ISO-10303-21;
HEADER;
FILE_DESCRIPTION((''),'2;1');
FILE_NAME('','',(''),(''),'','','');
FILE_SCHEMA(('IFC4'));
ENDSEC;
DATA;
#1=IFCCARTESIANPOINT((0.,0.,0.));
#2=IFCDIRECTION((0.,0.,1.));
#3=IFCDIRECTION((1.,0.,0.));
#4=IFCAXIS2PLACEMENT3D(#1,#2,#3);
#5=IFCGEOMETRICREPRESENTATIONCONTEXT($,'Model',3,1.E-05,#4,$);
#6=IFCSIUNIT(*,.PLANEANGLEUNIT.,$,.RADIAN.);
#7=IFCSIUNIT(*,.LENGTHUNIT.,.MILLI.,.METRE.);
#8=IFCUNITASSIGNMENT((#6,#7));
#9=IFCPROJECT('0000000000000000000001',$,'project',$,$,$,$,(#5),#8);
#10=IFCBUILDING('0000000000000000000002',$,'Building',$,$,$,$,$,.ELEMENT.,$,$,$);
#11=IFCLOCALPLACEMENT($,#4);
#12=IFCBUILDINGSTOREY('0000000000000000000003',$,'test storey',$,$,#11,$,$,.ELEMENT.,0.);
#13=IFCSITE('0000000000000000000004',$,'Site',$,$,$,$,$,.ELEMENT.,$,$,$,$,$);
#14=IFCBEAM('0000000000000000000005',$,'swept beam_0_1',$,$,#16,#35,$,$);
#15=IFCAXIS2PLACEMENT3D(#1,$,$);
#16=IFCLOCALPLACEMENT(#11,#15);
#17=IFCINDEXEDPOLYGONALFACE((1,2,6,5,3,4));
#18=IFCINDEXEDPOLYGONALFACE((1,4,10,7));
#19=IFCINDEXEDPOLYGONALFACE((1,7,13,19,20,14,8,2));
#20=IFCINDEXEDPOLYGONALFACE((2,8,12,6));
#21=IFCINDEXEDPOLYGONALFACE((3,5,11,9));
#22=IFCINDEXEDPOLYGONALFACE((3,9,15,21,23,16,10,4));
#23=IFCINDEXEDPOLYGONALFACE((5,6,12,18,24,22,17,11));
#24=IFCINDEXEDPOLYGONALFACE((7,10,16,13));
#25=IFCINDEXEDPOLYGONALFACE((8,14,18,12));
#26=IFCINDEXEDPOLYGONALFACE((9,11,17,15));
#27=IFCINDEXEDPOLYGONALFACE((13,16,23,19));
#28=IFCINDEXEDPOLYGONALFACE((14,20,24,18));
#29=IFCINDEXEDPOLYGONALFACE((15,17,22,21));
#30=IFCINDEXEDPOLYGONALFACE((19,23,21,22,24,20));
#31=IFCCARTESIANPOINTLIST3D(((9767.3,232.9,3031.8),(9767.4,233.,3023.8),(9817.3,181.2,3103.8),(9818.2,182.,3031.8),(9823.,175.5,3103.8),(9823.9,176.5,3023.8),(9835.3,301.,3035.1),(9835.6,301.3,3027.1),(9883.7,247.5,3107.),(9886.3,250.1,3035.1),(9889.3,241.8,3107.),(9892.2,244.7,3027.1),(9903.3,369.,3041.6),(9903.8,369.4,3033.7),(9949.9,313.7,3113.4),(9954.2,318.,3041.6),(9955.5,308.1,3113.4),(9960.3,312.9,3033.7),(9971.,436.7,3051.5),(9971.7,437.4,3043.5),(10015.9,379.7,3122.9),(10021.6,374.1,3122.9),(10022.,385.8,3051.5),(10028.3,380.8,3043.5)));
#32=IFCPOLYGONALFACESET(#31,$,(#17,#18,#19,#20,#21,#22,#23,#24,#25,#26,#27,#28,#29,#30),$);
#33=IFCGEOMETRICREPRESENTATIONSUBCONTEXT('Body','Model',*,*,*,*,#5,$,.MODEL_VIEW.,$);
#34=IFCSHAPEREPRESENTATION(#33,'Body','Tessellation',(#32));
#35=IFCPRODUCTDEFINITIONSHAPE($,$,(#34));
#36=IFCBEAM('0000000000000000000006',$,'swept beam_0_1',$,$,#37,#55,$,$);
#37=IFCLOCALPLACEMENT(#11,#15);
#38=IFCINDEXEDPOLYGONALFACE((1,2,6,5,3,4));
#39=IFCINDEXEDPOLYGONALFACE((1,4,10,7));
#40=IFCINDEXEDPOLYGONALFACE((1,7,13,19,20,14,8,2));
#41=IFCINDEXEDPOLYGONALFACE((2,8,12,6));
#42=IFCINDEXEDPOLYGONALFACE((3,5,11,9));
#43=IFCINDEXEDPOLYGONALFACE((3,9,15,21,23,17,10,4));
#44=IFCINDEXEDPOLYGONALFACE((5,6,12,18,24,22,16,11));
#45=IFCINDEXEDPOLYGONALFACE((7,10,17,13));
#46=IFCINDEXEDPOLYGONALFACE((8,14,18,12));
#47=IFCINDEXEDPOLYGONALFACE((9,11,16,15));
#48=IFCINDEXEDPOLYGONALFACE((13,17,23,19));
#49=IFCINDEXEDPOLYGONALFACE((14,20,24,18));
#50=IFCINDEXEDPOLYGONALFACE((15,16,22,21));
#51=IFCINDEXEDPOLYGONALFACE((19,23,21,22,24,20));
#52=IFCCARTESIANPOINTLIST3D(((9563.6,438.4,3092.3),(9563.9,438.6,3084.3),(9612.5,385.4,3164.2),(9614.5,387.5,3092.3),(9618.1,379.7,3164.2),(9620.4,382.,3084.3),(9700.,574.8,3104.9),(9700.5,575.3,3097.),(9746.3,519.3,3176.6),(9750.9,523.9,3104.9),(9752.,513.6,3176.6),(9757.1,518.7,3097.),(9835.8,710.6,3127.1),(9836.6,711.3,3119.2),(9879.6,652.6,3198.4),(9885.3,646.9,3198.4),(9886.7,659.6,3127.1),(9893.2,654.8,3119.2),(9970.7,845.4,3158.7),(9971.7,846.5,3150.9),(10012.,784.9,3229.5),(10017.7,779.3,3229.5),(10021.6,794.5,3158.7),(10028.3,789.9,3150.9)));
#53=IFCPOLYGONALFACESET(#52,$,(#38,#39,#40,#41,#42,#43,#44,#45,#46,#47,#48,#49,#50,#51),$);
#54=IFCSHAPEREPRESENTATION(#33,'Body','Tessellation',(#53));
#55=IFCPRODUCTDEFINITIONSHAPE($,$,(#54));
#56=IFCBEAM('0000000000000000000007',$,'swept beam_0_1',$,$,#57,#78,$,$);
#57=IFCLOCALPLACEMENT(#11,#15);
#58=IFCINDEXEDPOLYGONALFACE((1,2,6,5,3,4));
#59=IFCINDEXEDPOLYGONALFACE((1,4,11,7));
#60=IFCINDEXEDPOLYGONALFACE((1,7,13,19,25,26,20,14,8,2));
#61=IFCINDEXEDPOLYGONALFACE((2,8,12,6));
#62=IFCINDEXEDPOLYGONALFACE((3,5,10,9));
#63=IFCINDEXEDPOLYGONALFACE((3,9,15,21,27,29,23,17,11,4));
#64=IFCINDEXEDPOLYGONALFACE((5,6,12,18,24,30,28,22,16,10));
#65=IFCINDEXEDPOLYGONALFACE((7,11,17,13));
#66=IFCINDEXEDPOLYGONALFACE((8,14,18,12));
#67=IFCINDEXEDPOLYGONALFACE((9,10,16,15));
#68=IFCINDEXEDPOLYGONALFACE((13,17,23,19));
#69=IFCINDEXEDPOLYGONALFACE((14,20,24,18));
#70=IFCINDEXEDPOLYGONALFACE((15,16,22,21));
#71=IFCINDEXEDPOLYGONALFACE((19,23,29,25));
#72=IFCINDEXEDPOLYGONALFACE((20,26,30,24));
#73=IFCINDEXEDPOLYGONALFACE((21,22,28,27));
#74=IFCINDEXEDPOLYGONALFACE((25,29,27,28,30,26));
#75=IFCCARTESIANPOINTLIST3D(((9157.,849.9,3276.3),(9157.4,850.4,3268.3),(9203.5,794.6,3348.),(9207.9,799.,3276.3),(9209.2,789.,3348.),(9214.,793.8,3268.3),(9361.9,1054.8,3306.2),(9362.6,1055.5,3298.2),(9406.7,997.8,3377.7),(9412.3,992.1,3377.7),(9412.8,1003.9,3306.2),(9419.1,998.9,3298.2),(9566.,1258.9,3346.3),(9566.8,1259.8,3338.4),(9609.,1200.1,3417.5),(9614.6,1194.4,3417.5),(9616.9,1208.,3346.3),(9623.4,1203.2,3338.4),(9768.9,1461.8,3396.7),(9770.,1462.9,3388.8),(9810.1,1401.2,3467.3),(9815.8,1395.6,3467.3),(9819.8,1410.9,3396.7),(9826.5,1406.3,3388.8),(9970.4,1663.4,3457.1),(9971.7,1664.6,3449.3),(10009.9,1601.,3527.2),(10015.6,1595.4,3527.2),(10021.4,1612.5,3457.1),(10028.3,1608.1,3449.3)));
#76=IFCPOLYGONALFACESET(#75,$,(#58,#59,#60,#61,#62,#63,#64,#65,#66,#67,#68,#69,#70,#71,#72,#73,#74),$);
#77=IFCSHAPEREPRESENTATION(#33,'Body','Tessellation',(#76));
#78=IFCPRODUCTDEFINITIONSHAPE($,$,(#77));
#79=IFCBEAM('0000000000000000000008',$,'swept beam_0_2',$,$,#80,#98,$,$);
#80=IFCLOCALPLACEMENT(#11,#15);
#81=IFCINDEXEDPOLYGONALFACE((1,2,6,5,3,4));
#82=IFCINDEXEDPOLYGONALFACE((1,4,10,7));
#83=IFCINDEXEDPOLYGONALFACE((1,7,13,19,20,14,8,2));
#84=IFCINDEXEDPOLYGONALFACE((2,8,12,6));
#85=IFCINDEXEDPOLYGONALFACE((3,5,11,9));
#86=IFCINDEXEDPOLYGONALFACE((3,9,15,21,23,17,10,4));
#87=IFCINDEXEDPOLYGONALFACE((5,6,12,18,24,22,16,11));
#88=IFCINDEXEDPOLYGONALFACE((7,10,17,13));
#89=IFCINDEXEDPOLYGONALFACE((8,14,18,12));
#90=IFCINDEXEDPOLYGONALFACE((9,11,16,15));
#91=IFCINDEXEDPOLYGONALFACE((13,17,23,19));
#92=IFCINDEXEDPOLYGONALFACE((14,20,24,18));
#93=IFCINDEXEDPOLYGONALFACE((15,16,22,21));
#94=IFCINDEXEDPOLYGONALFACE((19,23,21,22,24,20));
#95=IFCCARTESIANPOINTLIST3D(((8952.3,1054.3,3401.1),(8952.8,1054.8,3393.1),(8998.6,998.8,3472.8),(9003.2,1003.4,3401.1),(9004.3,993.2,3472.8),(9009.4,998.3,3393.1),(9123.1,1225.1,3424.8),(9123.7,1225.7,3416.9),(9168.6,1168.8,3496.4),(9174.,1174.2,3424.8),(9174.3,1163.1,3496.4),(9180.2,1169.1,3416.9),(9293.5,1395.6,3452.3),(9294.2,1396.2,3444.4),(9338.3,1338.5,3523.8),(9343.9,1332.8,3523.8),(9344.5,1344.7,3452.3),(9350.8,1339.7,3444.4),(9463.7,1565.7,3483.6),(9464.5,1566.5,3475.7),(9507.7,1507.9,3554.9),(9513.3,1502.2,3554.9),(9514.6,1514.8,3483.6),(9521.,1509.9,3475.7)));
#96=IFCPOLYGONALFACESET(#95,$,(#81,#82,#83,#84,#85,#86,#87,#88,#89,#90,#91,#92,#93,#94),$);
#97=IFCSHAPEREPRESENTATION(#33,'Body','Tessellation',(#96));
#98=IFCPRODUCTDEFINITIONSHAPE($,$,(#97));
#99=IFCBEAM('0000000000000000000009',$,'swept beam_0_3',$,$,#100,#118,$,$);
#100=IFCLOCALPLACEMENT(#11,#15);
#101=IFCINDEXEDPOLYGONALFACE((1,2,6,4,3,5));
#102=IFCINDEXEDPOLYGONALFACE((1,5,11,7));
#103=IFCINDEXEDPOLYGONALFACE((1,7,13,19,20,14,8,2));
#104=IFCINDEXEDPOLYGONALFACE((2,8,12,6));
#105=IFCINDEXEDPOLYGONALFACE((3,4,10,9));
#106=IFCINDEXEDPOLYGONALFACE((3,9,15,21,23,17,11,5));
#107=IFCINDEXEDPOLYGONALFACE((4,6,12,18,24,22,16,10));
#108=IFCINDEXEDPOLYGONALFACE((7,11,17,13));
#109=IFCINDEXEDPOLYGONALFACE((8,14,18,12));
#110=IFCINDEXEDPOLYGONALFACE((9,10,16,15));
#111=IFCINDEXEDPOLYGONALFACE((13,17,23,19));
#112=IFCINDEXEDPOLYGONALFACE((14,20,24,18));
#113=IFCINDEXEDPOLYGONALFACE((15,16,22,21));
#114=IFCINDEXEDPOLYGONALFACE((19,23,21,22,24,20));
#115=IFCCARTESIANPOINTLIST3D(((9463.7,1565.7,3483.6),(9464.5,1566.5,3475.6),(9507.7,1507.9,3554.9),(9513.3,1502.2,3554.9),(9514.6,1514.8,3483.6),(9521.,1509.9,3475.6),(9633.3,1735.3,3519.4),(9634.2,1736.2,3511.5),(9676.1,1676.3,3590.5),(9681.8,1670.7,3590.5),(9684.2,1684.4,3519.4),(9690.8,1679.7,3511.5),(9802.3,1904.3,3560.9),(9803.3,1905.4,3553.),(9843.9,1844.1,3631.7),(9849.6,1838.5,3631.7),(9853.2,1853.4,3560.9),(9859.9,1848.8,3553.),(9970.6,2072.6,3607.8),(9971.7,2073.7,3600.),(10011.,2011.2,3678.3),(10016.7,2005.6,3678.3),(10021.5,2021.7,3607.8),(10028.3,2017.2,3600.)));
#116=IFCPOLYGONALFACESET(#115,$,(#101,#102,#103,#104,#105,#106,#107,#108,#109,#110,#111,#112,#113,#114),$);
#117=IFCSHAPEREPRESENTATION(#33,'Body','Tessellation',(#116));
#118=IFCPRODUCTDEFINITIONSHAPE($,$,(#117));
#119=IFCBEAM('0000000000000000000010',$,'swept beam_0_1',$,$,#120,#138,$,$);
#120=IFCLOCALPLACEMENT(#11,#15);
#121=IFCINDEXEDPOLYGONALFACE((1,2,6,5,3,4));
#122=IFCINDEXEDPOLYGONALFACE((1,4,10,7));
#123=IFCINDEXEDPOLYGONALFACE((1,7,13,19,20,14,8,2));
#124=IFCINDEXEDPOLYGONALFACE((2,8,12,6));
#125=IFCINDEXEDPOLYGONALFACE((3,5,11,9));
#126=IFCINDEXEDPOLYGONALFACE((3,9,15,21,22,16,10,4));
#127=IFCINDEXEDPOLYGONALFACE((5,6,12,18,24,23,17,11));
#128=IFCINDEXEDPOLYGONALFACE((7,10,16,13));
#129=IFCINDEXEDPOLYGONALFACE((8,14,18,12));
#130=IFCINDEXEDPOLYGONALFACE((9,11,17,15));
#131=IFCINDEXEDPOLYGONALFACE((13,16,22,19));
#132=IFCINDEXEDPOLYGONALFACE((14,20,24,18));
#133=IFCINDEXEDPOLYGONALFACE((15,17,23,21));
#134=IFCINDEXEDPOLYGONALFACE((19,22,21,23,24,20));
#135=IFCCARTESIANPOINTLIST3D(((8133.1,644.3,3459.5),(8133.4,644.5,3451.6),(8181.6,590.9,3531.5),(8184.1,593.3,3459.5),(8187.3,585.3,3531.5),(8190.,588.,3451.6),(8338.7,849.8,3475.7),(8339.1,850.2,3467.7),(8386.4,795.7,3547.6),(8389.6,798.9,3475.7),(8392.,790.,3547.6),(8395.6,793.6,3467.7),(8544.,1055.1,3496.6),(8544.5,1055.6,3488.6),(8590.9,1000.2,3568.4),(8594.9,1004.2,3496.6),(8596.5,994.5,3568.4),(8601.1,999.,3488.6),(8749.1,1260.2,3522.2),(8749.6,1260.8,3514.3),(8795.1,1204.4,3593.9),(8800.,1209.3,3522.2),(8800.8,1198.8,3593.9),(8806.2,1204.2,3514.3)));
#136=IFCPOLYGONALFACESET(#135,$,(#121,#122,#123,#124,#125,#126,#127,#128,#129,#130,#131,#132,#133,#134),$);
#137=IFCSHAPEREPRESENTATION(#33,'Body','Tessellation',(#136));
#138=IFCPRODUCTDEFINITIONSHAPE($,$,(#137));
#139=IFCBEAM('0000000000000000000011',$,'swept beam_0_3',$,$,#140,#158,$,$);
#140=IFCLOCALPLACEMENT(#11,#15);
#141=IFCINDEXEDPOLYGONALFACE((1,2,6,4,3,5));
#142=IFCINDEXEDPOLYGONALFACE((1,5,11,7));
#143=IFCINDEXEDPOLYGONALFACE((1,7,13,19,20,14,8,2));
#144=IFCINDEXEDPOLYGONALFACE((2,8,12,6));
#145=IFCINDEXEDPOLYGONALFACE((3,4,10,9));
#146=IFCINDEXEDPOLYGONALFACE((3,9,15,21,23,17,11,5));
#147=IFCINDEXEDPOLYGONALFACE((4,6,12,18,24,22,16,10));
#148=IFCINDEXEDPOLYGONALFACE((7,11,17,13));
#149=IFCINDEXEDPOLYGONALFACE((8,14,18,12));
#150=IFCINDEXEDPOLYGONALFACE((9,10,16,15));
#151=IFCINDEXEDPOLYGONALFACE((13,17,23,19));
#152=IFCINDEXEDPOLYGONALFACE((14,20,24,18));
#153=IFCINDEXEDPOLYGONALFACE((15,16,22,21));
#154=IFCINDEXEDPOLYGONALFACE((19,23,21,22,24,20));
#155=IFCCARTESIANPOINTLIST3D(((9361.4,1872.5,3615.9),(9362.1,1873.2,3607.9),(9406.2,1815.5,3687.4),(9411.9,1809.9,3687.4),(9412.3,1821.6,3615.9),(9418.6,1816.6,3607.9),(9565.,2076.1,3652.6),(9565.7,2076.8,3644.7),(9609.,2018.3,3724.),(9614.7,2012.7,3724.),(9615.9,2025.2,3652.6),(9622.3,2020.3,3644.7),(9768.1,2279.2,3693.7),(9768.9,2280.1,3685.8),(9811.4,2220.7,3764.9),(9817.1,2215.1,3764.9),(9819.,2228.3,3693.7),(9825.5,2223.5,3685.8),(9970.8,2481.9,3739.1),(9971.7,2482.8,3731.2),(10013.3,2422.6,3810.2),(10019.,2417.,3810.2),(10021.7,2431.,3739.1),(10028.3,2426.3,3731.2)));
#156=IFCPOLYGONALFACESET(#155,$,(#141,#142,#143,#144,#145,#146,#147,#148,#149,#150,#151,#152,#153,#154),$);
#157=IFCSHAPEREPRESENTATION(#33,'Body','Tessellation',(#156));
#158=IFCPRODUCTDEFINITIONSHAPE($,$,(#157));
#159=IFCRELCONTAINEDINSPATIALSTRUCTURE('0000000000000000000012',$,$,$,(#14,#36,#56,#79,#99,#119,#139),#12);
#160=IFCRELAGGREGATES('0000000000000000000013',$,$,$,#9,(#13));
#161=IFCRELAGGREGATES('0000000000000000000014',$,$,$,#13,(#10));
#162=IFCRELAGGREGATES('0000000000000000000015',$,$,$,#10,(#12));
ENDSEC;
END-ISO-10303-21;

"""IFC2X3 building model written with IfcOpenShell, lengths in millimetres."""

from ifc_helpers import new_model, entity, si_unit, origin_with_axes, place, context, subcontext, project, spatial, element, save


model = new_model("IFC2X3")

# Units and contexts
model_context = context("Model", 3, precision=1e-05, world=origin_with_axes())
body_context = subcontext(model_context, "Body", "Model", "MODEL_VIEW")
ifc_project = project(units=[si_unit("PLANEANGLEUNIT", "RADIAN"), si_unit("LENGTHUNIT", "METRE", prefix="MILLI")], contexts=[model_context])

# Site, building, storey
site = spatial("IfcSite", under=ifc_project, Name="Site", CompositionType="ELEMENT")
building = spatial("IfcBuilding", under=site, Name="Building", CompositionType="ELEMENT")
storey_placement = place(None, origin_with_axes())
storey = spatial("IfcBuildingStorey", under=building, at=storey_placement, Name="test storey", CompositionType="ELEMENT", Elevation=0.0)

# Beams
beam_1_placement = place(storey_placement, origin_with_axes())
element("IfcBeam", 1, at=beam_1_placement, inside=storey, Name="swept beam_0_1", context=body_context, shape_type="SweptSolid", body=[
    entity("IfcRevolvedAreaSolid", entity("IfcArbitraryClosedProfileDef", "AREA", None, entity("IfcPolyline", [entity("IfcCartesianPoint", [-80.0, 40.0]), entity("IfcCartesianPoint", [-80.0, 32.0]), entity("IfcCartesianPoint", [-8.0, 32.0]), entity("IfcCartesianPoint", [-8.0, -40.0]), entity("IfcCartesianPoint", [0.0, -40.0]), entity("IfcCartesianPoint", [0.0, 40.0]), entity("IfcCartesianPoint", [-80.0, 40.0])])), entity("IfcAxis2Placement3D", entity("IfcCartesianPoint", [9795.7, 204.7, 3023.8]), entity("IfcDirection", [-0.707, -0.707, -0.0169]), entity("IfcDirection", [0.0119, 0.0119, -0.9999])), entity("IfcAxis1Placement", entity("IfcCartesianPoint", [-2833.5, 0.0, 0.0]), entity("IfcDirection", [0.0, 1.0, 0.0])), 0.102268),
])
beam_2_placement = place(storey_placement, origin_with_axes())
element("IfcBeam", 2, at=beam_2_placement, inside=storey, Name="swept beam_0_1", context=body_context, shape_type="SweptSolid", body=[
    entity("IfcRevolvedAreaSolid", entity("IfcArbitraryClosedProfileDef", "AREA", None, entity("IfcPolyline", [entity("IfcCartesianPoint", [-80.0, 40.0]), entity("IfcCartesianPoint", [-80.0, 32.0]), entity("IfcCartesianPoint", [-8.0, 32.0]), entity("IfcCartesianPoint", [-8.0, -40.0]), entity("IfcCartesianPoint", [0.0, -40.0]), entity("IfcCartesianPoint", [0.0, 40.0]), entity("IfcCartesianPoint", [-80.0, 40.0])])), entity("IfcAxis2Placement3D", entity("IfcCartesianPoint", [9592.1, 410.3, 3084.3]), entity("IfcDirection", [-0.7065, -0.7065, -0.0409]), entity("IfcDirection", [0.0289, 0.0289, -0.9992])), entity("IfcAxis1Placement", entity("IfcCartesianPoint", [-3923.5, 0.0, 0.0]), entity("IfcDirection", [0.0, 1.0, 0.0])), 0.14812),
])
beam_3_placement = place(storey_placement, origin_with_axes())
element("IfcBeam", 3, at=beam_3_placement, inside=storey, Name="swept beam_0_1", context=body_context, shape_type="SweptSolid", body=[
    entity("IfcRevolvedAreaSolid", entity("IfcArbitraryClosedProfileDef", "AREA", None, entity("IfcPolyline", [entity("IfcCartesianPoint", [-80.0, 40.0]), entity("IfcCartesianPoint", [-80.0, 32.0]), entity("IfcCartesianPoint", [-8.0, 32.0]), entity("IfcCartesianPoint", [-8.0, -40.0]), entity("IfcCartesianPoint", [0.0, -40.0]), entity("IfcCartesianPoint", [0.0, 40.0]), entity("IfcCartesianPoint", [-80.0, 40.0])])), entity("IfcAxis2Placement3D", entity("IfcCartesianPoint", [9185.7, 822.1, 3268.3]), entity("IfcDirection", [-0.7045, -0.7045, -0.0851]), entity("IfcDirection", [0.0601, 0.0601, -0.9964])), entity("IfcAxis1Placement", entity("IfcCartesianPoint", [-8250.9, 0.0, 0.0]), entity("IfcDirection", [0.0, 1.0, 0.0])), 0.141398),
])
beam_4_placement = place(storey_placement, origin_with_axes())
element("IfcBeam", 4, at=beam_4_placement, inside=storey, Name="swept beam_0_2", context=body_context, shape_type="SweptSolid", body=[
    entity("IfcRevolvedAreaSolid", entity("IfcArbitraryClosedProfileDef", "AREA", None, entity("IfcPolyline", [entity("IfcCartesianPoint", [-80.0, 40.0]), entity("IfcCartesianPoint", [-80.0, 32.0]), entity("IfcCartesianPoint", [-8.0, 32.0]), entity("IfcCartesianPoint", [-8.0, -40.0]), entity("IfcCartesianPoint", [0.0, -40.0]), entity("IfcCartesianPoint", [0.0, 40.0]), entity("IfcCartesianPoint", [-80.0, 40.0])])), entity("IfcAxis2Placement3D", entity("IfcCartesianPoint", [8981.1, 1026.5, 3393.1]), entity("IfcDirection", [-0.7042, -0.7042, -0.0901]), entity("IfcDirection", [0.0637, 0.0637, -0.9959])), entity("IfcAxis1Placement", entity("IfcCartesianPoint", [-15611.9, 0.0, 0.0]), entity("IfcDirection", [0.0, 1.0, 0.0])), 0.046654),
])
beam_5_placement = place(storey_placement, origin_with_axes())
element("IfcBeam", 5, at=beam_5_placement, inside=storey, Name="swept beam_0_3", context=body_context, shape_type="SweptSolid", body=[
    entity("IfcRevolvedAreaSolid", entity("IfcArbitraryClosedProfileDef", "AREA", None, entity("IfcPolyline", [entity("IfcCartesianPoint", [-80.0, 40.0]), entity("IfcCartesianPoint", [-80.0, 32.0]), entity("IfcCartesianPoint", [-8.0, 32.0]), entity("IfcCartesianPoint", [-8.0, -40.0]), entity("IfcCartesianPoint", [0.0, -40.0]), entity("IfcCartesianPoint", [0.0, 40.0]), entity("IfcCartesianPoint", [-80.0, 40.0])])), entity("IfcAxis2Placement3D", entity("IfcCartesianPoint", [9492.8, 1538.2, 3475.6]), entity("IfcDirection", [-0.7005, -0.7005, -0.1364]), entity("IfcDirection", [0.0965, 0.0965, -0.9906])), entity("IfcAxis1Placement", entity("IfcCartesianPoint", [-10456.3, 0.0, 0.0]), entity("IfcDirection", [0.0, 1.0, 0.0])), 0.069642),
])
beam_6_placement = place(storey_placement, origin_with_axes())
element("IfcBeam", 6, at=beam_6_placement, inside=storey, Name="swept beam_0_1", context=body_context, shape_type="SweptSolid", body=[
    entity("IfcRevolvedAreaSolid", entity("IfcArbitraryClosedProfileDef", "AREA", None, entity("IfcPolyline", [entity("IfcCartesianPoint", [-80.0, 40.0]), entity("IfcCartesianPoint", [-80.0, 32.0]), entity("IfcCartesianPoint", [-8.0, 32.0]), entity("IfcCartesianPoint", [-8.0, -40.0]), entity("IfcCartesianPoint", [0.0, -40.0]), entity("IfcCartesianPoint", [0.0, 40.0]), entity("IfcCartesianPoint", [-80.0, 40.0])])), entity("IfcAxis2Placement3D", entity("IfcCartesianPoint", [8161.7, 616.2, 3451.6]), entity("IfcDirection", [-0.7063, -0.7063, -0.0474]), entity("IfcDirection", [0.0335, 0.0335, -0.9989])), entity("IfcAxis1Placement", entity("IfcCartesianPoint", [-17896.5, 0.0, 0.0]), entity("IfcDirection", [0.0, 1.0, 0.0])), 0.048827),
])
beam_7_placement = place(storey_placement, origin_with_axes())
element("IfcBeam", 7, at=beam_7_placement, inside=storey, Name="swept beam_0_3", context=body_context, shape_type="SweptSolid", body=[
    entity("IfcRevolvedAreaSolid", entity("IfcArbitraryClosedProfileDef", "AREA", None, entity("IfcPolyline", [entity("IfcCartesianPoint", [-80.0, 40.0]), entity("IfcCartesianPoint", [-80.0, 32.0]), entity("IfcCartesianPoint", [-8.0, 32.0]), entity("IfcCartesianPoint", [-8.0, -40.0]), entity("IfcCartesianPoint", [0.0, -40.0]), entity("IfcCartesianPoint", [0.0, 40.0]), entity("IfcCartesianPoint", [-80.0, 40.0])])), entity("IfcAxis2Placement3D", entity("IfcCartesianPoint", [9390.3, 1844.9, 3607.9]), entity("IfcDirection", [-0.7021, -0.7021, -0.119]), entity("IfcDirection", [0.0842, 0.0842, -0.9929])), entity("IfcAxis1Placement", entity("IfcCartesianPoint", [-19132.7, 0.0, 0.0]), entity("IfcDirection", [0.0, 1.0, 0.0])), 0.045526),
])

save(model, "model.ifc")
